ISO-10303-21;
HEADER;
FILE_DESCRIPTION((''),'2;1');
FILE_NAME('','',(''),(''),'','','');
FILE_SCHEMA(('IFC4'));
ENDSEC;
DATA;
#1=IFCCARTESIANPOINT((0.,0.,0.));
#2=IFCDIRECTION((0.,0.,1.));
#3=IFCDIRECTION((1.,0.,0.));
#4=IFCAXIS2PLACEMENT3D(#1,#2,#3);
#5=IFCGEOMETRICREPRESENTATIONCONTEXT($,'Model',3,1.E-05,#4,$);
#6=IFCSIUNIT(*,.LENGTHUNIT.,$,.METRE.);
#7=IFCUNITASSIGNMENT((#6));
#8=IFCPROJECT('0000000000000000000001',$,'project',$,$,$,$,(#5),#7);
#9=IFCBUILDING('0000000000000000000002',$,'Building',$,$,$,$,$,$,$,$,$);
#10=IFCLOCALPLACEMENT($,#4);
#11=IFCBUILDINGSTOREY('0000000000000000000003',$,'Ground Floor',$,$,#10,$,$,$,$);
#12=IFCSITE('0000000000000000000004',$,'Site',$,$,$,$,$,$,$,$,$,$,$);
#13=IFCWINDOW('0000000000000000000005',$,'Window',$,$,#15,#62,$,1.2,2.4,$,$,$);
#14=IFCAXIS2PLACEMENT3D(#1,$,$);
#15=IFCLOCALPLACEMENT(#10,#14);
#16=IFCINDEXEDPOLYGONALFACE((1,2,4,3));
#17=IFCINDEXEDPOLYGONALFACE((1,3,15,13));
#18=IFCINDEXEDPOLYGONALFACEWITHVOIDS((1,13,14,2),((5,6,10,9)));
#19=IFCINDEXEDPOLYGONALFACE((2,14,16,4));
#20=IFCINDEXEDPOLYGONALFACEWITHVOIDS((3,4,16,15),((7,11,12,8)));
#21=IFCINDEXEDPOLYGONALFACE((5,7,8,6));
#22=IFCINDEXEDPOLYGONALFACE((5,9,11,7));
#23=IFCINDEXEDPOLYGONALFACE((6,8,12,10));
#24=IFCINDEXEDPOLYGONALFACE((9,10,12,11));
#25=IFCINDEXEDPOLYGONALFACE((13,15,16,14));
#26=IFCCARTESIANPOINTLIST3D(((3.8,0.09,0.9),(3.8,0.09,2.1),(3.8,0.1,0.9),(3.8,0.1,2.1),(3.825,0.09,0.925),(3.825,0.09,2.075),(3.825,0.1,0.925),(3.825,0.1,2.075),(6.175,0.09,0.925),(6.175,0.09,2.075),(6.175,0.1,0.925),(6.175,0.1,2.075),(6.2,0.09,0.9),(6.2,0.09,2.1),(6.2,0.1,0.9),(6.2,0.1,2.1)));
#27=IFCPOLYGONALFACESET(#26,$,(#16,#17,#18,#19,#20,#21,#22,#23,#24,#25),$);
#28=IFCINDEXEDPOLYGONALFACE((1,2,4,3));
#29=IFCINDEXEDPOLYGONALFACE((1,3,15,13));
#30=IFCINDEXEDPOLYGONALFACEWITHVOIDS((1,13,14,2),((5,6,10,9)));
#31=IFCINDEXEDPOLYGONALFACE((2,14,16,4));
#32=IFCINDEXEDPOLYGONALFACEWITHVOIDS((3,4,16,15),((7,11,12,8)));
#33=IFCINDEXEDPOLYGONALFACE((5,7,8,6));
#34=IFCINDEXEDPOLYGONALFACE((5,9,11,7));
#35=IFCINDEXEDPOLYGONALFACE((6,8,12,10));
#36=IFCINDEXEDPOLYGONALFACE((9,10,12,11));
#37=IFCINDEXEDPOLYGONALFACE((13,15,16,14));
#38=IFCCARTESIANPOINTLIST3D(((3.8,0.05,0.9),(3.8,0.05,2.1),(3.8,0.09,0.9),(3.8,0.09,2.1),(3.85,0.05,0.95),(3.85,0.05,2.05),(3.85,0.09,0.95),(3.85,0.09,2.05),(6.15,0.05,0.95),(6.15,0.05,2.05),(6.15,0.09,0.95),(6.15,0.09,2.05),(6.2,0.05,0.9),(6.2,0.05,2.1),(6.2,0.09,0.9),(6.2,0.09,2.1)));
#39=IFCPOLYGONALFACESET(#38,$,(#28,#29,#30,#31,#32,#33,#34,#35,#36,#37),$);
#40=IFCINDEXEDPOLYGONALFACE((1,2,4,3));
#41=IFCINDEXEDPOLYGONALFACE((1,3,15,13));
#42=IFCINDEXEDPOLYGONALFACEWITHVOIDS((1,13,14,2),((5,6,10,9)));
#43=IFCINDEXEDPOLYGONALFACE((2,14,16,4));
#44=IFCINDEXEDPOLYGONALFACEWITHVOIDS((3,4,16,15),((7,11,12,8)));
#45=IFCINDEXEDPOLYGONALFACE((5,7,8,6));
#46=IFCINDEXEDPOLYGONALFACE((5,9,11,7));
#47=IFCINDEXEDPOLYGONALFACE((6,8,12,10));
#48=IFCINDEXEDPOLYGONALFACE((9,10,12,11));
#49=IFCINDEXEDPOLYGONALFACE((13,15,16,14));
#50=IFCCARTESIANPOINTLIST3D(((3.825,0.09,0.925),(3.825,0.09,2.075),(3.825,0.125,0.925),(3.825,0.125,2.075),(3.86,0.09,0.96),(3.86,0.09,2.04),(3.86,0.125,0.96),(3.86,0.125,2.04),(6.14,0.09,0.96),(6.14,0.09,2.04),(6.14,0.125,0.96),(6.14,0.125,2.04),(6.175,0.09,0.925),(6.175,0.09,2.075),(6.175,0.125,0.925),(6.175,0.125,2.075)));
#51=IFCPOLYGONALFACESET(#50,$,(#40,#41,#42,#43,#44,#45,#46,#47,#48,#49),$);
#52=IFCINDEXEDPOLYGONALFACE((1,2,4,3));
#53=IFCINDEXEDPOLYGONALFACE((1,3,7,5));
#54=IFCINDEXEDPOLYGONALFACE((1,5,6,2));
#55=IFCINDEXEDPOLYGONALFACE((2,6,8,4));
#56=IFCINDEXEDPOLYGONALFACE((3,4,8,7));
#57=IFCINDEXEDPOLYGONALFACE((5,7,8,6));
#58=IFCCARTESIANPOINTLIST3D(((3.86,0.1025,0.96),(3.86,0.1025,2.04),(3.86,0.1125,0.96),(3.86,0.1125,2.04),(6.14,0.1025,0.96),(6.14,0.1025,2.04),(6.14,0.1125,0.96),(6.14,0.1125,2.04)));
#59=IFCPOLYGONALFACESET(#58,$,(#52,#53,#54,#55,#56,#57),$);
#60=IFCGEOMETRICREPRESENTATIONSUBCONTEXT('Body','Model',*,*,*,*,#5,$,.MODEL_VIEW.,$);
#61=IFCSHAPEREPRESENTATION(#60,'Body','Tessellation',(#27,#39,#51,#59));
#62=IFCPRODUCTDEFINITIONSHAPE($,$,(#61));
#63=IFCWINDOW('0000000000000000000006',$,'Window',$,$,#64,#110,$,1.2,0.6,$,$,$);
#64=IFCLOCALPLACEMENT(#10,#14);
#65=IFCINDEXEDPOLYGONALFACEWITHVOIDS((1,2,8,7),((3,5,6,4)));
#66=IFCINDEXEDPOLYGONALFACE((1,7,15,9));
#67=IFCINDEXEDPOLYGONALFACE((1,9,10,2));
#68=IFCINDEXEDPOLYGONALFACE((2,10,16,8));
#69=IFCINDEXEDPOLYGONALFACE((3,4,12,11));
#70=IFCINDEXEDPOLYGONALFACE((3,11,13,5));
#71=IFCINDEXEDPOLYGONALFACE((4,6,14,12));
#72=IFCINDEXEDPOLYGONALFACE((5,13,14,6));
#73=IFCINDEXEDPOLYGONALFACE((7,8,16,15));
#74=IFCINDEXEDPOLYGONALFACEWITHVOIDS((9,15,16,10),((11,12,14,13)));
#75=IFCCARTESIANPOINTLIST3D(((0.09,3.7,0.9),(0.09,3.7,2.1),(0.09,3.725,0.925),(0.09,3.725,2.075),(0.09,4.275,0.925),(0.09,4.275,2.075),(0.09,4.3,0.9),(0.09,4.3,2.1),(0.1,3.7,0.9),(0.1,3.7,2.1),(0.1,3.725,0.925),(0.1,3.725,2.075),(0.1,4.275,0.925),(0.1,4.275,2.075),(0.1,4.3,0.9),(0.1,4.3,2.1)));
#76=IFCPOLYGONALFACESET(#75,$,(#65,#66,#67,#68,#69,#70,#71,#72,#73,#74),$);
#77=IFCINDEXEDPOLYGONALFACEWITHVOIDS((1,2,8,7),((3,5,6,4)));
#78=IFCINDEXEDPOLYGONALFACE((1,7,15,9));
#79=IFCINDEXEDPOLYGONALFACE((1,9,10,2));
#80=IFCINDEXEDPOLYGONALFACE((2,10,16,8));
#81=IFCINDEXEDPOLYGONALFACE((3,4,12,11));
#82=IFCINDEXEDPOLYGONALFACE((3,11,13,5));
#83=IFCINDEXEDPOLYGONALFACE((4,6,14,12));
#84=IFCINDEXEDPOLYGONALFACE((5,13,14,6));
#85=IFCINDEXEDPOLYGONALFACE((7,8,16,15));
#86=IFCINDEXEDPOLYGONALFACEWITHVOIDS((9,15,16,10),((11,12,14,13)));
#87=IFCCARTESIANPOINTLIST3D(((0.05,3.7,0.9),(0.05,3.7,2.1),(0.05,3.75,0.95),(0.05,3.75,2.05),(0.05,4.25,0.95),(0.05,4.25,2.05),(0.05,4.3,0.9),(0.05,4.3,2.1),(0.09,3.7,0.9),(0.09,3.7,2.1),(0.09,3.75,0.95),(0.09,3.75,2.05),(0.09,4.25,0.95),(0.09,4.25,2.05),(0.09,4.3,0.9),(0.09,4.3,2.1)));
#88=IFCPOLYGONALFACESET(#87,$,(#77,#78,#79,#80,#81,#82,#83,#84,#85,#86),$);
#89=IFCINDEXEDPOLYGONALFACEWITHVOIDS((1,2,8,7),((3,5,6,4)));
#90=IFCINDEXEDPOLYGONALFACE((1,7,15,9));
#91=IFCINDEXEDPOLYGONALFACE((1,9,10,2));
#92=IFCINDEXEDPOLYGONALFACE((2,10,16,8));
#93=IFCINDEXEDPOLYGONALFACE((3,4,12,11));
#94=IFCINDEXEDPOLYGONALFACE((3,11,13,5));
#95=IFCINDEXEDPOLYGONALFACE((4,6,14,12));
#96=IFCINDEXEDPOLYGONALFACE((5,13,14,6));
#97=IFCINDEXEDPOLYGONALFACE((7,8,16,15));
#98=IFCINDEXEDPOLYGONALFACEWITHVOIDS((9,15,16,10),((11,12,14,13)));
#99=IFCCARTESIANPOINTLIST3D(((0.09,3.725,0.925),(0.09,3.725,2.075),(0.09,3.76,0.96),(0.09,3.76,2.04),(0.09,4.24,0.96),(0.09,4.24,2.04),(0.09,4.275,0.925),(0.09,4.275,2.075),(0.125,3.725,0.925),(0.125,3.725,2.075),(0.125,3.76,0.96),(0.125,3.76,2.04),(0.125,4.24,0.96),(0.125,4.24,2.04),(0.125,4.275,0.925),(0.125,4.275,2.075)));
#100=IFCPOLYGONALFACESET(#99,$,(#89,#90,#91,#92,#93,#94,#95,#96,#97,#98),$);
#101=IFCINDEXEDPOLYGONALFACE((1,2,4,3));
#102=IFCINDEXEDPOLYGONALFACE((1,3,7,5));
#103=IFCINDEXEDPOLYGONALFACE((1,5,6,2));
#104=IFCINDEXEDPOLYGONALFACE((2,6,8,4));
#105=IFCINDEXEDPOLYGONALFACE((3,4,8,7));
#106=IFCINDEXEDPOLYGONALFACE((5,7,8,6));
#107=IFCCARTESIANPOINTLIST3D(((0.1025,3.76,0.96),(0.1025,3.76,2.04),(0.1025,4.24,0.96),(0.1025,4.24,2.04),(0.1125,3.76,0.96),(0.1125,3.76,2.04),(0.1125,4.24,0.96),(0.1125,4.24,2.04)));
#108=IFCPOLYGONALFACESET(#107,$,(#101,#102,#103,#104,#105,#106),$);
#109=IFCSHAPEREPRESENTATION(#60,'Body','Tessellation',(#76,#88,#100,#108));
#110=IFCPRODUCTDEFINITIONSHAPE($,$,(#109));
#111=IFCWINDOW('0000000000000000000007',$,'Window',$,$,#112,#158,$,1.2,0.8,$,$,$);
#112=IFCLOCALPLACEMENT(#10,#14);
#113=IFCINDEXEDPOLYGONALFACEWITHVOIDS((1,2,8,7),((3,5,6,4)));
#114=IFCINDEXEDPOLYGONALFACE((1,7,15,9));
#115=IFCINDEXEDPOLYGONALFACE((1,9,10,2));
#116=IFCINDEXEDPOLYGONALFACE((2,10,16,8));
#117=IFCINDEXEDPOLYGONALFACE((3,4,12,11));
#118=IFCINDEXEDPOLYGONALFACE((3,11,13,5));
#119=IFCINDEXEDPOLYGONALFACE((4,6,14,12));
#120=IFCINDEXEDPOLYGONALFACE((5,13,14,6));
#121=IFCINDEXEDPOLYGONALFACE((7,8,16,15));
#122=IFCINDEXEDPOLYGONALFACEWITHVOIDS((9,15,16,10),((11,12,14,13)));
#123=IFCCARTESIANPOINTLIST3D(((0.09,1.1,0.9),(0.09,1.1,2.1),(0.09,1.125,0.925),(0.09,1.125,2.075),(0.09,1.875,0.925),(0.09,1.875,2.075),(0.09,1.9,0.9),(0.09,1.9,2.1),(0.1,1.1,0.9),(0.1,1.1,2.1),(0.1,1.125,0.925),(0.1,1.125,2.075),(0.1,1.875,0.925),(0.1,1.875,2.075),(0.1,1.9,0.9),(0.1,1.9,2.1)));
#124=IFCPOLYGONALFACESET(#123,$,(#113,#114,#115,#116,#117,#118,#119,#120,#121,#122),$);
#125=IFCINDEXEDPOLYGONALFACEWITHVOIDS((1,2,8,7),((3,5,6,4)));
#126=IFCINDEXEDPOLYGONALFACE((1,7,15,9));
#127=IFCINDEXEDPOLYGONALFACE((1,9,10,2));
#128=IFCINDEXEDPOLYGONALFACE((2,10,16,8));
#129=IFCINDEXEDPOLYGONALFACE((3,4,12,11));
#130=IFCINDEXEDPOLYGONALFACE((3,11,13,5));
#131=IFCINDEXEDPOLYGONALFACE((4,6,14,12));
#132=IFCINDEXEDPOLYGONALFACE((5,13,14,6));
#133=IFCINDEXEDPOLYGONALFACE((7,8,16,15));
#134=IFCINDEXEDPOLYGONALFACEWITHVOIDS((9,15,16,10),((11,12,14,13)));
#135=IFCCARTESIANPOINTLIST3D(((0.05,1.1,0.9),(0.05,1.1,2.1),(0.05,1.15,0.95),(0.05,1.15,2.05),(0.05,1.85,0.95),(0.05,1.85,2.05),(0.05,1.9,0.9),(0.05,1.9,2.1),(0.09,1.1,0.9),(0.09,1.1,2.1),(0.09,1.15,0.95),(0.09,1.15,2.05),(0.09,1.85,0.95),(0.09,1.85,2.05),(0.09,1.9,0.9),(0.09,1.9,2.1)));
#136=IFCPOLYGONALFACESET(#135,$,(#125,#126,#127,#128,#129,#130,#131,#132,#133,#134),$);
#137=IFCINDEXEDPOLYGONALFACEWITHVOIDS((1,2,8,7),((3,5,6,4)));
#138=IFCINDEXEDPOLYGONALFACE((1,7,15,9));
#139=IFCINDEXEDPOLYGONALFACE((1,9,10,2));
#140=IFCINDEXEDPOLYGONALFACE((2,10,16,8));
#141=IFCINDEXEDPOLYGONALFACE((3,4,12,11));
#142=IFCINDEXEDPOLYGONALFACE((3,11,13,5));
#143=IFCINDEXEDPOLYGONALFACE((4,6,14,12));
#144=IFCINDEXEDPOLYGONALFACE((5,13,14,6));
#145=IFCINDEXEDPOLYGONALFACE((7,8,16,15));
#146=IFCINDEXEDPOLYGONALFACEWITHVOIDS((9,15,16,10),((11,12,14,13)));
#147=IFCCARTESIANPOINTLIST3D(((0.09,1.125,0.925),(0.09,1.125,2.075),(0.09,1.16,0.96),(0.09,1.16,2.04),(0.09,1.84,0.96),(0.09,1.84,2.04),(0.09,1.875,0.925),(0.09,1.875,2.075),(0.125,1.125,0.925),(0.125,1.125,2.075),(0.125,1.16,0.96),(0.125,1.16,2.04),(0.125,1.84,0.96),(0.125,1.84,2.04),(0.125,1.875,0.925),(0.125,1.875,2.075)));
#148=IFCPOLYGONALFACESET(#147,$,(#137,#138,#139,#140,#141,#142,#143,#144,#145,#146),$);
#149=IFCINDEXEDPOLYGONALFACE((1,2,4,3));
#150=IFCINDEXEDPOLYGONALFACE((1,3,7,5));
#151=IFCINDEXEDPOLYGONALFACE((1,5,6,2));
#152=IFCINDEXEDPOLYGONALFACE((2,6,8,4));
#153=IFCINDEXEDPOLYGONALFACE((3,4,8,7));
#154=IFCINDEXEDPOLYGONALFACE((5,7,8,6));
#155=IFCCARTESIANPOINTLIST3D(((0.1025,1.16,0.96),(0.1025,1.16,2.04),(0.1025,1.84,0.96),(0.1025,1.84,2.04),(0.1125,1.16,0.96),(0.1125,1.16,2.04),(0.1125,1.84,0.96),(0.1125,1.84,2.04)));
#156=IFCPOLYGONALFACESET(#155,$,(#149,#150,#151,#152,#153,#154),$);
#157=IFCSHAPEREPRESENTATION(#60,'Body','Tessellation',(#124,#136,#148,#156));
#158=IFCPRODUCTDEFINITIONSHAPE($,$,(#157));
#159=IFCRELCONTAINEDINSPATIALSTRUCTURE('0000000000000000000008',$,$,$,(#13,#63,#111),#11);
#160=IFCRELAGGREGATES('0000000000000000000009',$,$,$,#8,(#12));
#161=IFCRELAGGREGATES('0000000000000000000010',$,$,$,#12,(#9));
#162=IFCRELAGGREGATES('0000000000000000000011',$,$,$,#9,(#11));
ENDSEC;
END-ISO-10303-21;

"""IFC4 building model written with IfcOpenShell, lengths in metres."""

from ifc_helpers import new_model, si_unit, frame, origin_with_axes, place, context, subcontext, project, spatial, line, indexed_curve, outline, extrude, element, save


model = new_model("IFC4")

# Units and contexts
model_context = context("Model", 3, precision=1e-05, world=origin_with_axes())
body_context = subcontext(model_context, "Body", "Model", "MODEL_VIEW")
ifc_project = project(units=[si_unit("LENGTHUNIT", "METRE")], contexts=[model_context])

# Site, building, storey
site = spatial("IfcSite", under=ifc_project, Name="Site")
building = spatial("IfcBuilding", under=site, Name="Building")
storey_placement = place(None, origin_with_axes())
storey = spatial("IfcBuildingStorey", under=building, at=storey_placement, Name="Ground Floor")

# Windows
window_1_placement = place(storey_placement, frame((3.8, 0.0, 0.9), z_axis=(0.0, 0.0, 1.0), x_axis=(1.0, 0.0, 0.0)))
element("IfcWindow", 1, at=window_1_placement, inside=storey, Name="Window", OverallHeight=1.2, OverallWidth=2.4, context=body_context, shape_type="SweptSolid", body=[
    extrude(outline(indexed_curve([(0.0, 0.0), (2.4, 0.0), (2.4, 1.2), (0.0, 1.2)], segments=[line(1, 2, 3, 4, 1)]), holes=[indexed_curve([(0.025, 0.025), (2.375, 0.025), (2.375, 1.175), (0.025, 1.175)], segments=[line(1, 2, 3, 4, 1)])]), frame((0.0, 0.09, 0.0), z_axis=(0.0, -1.0, 0.0), x_axis=(1.0, 0.0, 0.0)), (0.0, 0.0, -1.0), 0.01),
    extrude(outline(indexed_curve([(0.0, 0.0), (2.4, 0.0), (2.4, 1.2), (0.0, 1.2)], segments=[line(1, 2, 3, 4, 1)]), holes=[indexed_curve([(0.05, 0.05), (2.35, 0.05), (2.35, 1.15), (0.05, 1.15)], segments=[line(1, 2, 3, 4, 1)])]), frame((0.0, 0.05, 0.0), z_axis=(0.0, -1.0, 0.0), x_axis=(1.0, 0.0, 0.0)), (0.0, 0.0, -1.0), 0.04),
    extrude(outline(indexed_curve([(0.0, 0.0), (2.35, 0.0), (2.35, 1.15), (0.0, 1.15)], segments=[line(1, 2, 3, 4, 1)]), holes=[indexed_curve([(0.035, 0.035), (2.315, 0.035), (2.315, 1.115), (0.035, 1.115)], segments=[line(1, 2, 3, 4, 1)])]), frame((0.025, 0.09, 0.025), z_axis=(0.0, -1.0, 0.0), x_axis=(1.0, 0.0, 0.0)), (0.0, 0.0, -1.0), 0.035),
    extrude(outline(indexed_curve([(0.035, 0.035), (2.315, 0.035), (2.315, 1.115), (0.035, 1.115)], segments=[line(1, 2, 3, 4, 1)])), frame((0.025, 0.1025, 0.025), z_axis=(0.0, -1.0, 0.0), x_axis=(1.0, 0.0, 0.0)), (0.0, 0.0, -1.0), 0.01),
])
window_2_placement = place(storey_placement, frame((0.0, 4.3, 0.9), z_axis=(0.0, 0.0, 1.0), x_axis=(0.0, -1.0, 0.0)))
element("IfcWindow", 2, at=window_2_placement, inside=storey, Name="Window", OverallHeight=1.2, OverallWidth=0.6, context=body_context, shape_type="SweptSolid", body=[
    extrude(outline(indexed_curve([(0.0, 0.0), (0.6, 0.0), (0.6, 1.2), (0.0, 1.2)], segments=[line(1, 2, 3, 4, 1)]), holes=[indexed_curve([(0.025, 0.025), (0.575, 0.025), (0.575, 1.175), (0.025, 1.175)], segments=[line(1, 2, 3, 4, 1)])]), frame((0.0, 0.09, 0.0), z_axis=(0.0, -1.0, 0.0), x_axis=(1.0, 0.0, 0.0)), (0.0, 0.0, -1.0), 0.01),
    extrude(outline(indexed_curve([(0.0, 0.0), (0.6, 0.0), (0.6, 1.2), (0.0, 1.2)], segments=[line(1, 2, 3, 4, 1)]), holes=[indexed_curve([(0.05, 0.05), (0.55, 0.05), (0.55, 1.15), (0.05, 1.15)], segments=[line(1, 2, 3, 4, 1)])]), frame((0.0, 0.05, 0.0), z_axis=(0.0, -1.0, 0.0), x_axis=(1.0, 0.0, 0.0)), (0.0, 0.0, -1.0), 0.04),
    extrude(outline(indexed_curve([(0.0, 0.0), (0.55, 0.0), (0.55, 1.15), (0.0, 1.15)], segments=[line(1, 2, 3, 4, 1)]), holes=[indexed_curve([(0.035, 0.035), (0.515, 0.035), (0.515, 1.115), (0.035, 1.115)], segments=[line(1, 2, 3, 4, 1)])]), frame((0.025, 0.09, 0.025), z_axis=(0.0, -1.0, 0.0), x_axis=(1.0, 0.0, 0.0)), (0.0, 0.0, -1.0), 0.035),
    extrude(outline(indexed_curve([(0.035, 0.035), (0.515, 0.035), (0.515, 1.115), (0.035, 1.115)], segments=[line(1, 2, 3, 4, 1)])), frame((0.025, 0.1025, 0.025), z_axis=(0.0, -1.0, 0.0), x_axis=(1.0, 0.0, 0.0)), (0.0, 0.0, -1.0), 0.01),
])
window_3_placement = place(storey_placement, frame((0.0, 1.9, 0.9), z_axis=(0.0, 0.0, 1.0), x_axis=(0.0, -1.0, 0.0)))
element("IfcWindow", 3, at=window_3_placement, inside=storey, Name="Window", OverallHeight=1.2, OverallWidth=0.8, context=body_context, shape_type="SweptSolid", body=[
    extrude(outline(indexed_curve([(0.0, 0.0), (0.8, 0.0), (0.8, 1.2), (0.0, 1.2)], segments=[line(1, 2, 3, 4, 1)]), holes=[indexed_curve([(0.025, 0.025), (0.775, 0.025), (0.775, 1.175), (0.025, 1.175)], segments=[line(1, 2, 3, 4, 1)])]), frame((0.0, 0.09, 0.0), z_axis=(0.0, -1.0, 0.0), x_axis=(1.0, 0.0, 0.0)), (0.0, 0.0, -1.0), 0.01),
    extrude(outline(indexed_curve([(0.0, 0.0), (0.8, 0.0), (0.8, 1.2), (0.0, 1.2)], segments=[line(1, 2, 3, 4, 1)]), holes=[indexed_curve([(0.05, 0.05), (0.75, 0.05), (0.75, 1.15), (0.05, 1.15)], segments=[line(1, 2, 3, 4, 1)])]), frame((0.0, 0.05, 0.0), z_axis=(0.0, -1.0, 0.0), x_axis=(1.0, 0.0, 0.0)), (0.0, 0.0, -1.0), 0.04),
    extrude(outline(indexed_curve([(0.0, 0.0), (0.75, 0.0), (0.75, 1.15), (0.0, 1.15)], segments=[line(1, 2, 3, 4, 1)]), holes=[indexed_curve([(0.035, 0.035), (0.715, 0.035), (0.715, 1.115), (0.035, 1.115)], segments=[line(1, 2, 3, 4, 1)])]), frame((0.025, 0.09, 0.025), z_axis=(0.0, -1.0, 0.0), x_axis=(1.0, 0.0, 0.0)), (0.0, 0.0, -1.0), 0.035),
    extrude(outline(indexed_curve([(0.035, 0.035), (0.715, 0.035), (0.715, 1.115), (0.035, 1.115)], segments=[line(1, 2, 3, 4, 1)])), frame((0.025, 0.1025, 0.025), z_axis=(0.0, -1.0, 0.0), x_axis=(1.0, 0.0, 0.0)), (0.0, 0.0, -1.0), 0.01),
])

save(model, "model.ifc")
